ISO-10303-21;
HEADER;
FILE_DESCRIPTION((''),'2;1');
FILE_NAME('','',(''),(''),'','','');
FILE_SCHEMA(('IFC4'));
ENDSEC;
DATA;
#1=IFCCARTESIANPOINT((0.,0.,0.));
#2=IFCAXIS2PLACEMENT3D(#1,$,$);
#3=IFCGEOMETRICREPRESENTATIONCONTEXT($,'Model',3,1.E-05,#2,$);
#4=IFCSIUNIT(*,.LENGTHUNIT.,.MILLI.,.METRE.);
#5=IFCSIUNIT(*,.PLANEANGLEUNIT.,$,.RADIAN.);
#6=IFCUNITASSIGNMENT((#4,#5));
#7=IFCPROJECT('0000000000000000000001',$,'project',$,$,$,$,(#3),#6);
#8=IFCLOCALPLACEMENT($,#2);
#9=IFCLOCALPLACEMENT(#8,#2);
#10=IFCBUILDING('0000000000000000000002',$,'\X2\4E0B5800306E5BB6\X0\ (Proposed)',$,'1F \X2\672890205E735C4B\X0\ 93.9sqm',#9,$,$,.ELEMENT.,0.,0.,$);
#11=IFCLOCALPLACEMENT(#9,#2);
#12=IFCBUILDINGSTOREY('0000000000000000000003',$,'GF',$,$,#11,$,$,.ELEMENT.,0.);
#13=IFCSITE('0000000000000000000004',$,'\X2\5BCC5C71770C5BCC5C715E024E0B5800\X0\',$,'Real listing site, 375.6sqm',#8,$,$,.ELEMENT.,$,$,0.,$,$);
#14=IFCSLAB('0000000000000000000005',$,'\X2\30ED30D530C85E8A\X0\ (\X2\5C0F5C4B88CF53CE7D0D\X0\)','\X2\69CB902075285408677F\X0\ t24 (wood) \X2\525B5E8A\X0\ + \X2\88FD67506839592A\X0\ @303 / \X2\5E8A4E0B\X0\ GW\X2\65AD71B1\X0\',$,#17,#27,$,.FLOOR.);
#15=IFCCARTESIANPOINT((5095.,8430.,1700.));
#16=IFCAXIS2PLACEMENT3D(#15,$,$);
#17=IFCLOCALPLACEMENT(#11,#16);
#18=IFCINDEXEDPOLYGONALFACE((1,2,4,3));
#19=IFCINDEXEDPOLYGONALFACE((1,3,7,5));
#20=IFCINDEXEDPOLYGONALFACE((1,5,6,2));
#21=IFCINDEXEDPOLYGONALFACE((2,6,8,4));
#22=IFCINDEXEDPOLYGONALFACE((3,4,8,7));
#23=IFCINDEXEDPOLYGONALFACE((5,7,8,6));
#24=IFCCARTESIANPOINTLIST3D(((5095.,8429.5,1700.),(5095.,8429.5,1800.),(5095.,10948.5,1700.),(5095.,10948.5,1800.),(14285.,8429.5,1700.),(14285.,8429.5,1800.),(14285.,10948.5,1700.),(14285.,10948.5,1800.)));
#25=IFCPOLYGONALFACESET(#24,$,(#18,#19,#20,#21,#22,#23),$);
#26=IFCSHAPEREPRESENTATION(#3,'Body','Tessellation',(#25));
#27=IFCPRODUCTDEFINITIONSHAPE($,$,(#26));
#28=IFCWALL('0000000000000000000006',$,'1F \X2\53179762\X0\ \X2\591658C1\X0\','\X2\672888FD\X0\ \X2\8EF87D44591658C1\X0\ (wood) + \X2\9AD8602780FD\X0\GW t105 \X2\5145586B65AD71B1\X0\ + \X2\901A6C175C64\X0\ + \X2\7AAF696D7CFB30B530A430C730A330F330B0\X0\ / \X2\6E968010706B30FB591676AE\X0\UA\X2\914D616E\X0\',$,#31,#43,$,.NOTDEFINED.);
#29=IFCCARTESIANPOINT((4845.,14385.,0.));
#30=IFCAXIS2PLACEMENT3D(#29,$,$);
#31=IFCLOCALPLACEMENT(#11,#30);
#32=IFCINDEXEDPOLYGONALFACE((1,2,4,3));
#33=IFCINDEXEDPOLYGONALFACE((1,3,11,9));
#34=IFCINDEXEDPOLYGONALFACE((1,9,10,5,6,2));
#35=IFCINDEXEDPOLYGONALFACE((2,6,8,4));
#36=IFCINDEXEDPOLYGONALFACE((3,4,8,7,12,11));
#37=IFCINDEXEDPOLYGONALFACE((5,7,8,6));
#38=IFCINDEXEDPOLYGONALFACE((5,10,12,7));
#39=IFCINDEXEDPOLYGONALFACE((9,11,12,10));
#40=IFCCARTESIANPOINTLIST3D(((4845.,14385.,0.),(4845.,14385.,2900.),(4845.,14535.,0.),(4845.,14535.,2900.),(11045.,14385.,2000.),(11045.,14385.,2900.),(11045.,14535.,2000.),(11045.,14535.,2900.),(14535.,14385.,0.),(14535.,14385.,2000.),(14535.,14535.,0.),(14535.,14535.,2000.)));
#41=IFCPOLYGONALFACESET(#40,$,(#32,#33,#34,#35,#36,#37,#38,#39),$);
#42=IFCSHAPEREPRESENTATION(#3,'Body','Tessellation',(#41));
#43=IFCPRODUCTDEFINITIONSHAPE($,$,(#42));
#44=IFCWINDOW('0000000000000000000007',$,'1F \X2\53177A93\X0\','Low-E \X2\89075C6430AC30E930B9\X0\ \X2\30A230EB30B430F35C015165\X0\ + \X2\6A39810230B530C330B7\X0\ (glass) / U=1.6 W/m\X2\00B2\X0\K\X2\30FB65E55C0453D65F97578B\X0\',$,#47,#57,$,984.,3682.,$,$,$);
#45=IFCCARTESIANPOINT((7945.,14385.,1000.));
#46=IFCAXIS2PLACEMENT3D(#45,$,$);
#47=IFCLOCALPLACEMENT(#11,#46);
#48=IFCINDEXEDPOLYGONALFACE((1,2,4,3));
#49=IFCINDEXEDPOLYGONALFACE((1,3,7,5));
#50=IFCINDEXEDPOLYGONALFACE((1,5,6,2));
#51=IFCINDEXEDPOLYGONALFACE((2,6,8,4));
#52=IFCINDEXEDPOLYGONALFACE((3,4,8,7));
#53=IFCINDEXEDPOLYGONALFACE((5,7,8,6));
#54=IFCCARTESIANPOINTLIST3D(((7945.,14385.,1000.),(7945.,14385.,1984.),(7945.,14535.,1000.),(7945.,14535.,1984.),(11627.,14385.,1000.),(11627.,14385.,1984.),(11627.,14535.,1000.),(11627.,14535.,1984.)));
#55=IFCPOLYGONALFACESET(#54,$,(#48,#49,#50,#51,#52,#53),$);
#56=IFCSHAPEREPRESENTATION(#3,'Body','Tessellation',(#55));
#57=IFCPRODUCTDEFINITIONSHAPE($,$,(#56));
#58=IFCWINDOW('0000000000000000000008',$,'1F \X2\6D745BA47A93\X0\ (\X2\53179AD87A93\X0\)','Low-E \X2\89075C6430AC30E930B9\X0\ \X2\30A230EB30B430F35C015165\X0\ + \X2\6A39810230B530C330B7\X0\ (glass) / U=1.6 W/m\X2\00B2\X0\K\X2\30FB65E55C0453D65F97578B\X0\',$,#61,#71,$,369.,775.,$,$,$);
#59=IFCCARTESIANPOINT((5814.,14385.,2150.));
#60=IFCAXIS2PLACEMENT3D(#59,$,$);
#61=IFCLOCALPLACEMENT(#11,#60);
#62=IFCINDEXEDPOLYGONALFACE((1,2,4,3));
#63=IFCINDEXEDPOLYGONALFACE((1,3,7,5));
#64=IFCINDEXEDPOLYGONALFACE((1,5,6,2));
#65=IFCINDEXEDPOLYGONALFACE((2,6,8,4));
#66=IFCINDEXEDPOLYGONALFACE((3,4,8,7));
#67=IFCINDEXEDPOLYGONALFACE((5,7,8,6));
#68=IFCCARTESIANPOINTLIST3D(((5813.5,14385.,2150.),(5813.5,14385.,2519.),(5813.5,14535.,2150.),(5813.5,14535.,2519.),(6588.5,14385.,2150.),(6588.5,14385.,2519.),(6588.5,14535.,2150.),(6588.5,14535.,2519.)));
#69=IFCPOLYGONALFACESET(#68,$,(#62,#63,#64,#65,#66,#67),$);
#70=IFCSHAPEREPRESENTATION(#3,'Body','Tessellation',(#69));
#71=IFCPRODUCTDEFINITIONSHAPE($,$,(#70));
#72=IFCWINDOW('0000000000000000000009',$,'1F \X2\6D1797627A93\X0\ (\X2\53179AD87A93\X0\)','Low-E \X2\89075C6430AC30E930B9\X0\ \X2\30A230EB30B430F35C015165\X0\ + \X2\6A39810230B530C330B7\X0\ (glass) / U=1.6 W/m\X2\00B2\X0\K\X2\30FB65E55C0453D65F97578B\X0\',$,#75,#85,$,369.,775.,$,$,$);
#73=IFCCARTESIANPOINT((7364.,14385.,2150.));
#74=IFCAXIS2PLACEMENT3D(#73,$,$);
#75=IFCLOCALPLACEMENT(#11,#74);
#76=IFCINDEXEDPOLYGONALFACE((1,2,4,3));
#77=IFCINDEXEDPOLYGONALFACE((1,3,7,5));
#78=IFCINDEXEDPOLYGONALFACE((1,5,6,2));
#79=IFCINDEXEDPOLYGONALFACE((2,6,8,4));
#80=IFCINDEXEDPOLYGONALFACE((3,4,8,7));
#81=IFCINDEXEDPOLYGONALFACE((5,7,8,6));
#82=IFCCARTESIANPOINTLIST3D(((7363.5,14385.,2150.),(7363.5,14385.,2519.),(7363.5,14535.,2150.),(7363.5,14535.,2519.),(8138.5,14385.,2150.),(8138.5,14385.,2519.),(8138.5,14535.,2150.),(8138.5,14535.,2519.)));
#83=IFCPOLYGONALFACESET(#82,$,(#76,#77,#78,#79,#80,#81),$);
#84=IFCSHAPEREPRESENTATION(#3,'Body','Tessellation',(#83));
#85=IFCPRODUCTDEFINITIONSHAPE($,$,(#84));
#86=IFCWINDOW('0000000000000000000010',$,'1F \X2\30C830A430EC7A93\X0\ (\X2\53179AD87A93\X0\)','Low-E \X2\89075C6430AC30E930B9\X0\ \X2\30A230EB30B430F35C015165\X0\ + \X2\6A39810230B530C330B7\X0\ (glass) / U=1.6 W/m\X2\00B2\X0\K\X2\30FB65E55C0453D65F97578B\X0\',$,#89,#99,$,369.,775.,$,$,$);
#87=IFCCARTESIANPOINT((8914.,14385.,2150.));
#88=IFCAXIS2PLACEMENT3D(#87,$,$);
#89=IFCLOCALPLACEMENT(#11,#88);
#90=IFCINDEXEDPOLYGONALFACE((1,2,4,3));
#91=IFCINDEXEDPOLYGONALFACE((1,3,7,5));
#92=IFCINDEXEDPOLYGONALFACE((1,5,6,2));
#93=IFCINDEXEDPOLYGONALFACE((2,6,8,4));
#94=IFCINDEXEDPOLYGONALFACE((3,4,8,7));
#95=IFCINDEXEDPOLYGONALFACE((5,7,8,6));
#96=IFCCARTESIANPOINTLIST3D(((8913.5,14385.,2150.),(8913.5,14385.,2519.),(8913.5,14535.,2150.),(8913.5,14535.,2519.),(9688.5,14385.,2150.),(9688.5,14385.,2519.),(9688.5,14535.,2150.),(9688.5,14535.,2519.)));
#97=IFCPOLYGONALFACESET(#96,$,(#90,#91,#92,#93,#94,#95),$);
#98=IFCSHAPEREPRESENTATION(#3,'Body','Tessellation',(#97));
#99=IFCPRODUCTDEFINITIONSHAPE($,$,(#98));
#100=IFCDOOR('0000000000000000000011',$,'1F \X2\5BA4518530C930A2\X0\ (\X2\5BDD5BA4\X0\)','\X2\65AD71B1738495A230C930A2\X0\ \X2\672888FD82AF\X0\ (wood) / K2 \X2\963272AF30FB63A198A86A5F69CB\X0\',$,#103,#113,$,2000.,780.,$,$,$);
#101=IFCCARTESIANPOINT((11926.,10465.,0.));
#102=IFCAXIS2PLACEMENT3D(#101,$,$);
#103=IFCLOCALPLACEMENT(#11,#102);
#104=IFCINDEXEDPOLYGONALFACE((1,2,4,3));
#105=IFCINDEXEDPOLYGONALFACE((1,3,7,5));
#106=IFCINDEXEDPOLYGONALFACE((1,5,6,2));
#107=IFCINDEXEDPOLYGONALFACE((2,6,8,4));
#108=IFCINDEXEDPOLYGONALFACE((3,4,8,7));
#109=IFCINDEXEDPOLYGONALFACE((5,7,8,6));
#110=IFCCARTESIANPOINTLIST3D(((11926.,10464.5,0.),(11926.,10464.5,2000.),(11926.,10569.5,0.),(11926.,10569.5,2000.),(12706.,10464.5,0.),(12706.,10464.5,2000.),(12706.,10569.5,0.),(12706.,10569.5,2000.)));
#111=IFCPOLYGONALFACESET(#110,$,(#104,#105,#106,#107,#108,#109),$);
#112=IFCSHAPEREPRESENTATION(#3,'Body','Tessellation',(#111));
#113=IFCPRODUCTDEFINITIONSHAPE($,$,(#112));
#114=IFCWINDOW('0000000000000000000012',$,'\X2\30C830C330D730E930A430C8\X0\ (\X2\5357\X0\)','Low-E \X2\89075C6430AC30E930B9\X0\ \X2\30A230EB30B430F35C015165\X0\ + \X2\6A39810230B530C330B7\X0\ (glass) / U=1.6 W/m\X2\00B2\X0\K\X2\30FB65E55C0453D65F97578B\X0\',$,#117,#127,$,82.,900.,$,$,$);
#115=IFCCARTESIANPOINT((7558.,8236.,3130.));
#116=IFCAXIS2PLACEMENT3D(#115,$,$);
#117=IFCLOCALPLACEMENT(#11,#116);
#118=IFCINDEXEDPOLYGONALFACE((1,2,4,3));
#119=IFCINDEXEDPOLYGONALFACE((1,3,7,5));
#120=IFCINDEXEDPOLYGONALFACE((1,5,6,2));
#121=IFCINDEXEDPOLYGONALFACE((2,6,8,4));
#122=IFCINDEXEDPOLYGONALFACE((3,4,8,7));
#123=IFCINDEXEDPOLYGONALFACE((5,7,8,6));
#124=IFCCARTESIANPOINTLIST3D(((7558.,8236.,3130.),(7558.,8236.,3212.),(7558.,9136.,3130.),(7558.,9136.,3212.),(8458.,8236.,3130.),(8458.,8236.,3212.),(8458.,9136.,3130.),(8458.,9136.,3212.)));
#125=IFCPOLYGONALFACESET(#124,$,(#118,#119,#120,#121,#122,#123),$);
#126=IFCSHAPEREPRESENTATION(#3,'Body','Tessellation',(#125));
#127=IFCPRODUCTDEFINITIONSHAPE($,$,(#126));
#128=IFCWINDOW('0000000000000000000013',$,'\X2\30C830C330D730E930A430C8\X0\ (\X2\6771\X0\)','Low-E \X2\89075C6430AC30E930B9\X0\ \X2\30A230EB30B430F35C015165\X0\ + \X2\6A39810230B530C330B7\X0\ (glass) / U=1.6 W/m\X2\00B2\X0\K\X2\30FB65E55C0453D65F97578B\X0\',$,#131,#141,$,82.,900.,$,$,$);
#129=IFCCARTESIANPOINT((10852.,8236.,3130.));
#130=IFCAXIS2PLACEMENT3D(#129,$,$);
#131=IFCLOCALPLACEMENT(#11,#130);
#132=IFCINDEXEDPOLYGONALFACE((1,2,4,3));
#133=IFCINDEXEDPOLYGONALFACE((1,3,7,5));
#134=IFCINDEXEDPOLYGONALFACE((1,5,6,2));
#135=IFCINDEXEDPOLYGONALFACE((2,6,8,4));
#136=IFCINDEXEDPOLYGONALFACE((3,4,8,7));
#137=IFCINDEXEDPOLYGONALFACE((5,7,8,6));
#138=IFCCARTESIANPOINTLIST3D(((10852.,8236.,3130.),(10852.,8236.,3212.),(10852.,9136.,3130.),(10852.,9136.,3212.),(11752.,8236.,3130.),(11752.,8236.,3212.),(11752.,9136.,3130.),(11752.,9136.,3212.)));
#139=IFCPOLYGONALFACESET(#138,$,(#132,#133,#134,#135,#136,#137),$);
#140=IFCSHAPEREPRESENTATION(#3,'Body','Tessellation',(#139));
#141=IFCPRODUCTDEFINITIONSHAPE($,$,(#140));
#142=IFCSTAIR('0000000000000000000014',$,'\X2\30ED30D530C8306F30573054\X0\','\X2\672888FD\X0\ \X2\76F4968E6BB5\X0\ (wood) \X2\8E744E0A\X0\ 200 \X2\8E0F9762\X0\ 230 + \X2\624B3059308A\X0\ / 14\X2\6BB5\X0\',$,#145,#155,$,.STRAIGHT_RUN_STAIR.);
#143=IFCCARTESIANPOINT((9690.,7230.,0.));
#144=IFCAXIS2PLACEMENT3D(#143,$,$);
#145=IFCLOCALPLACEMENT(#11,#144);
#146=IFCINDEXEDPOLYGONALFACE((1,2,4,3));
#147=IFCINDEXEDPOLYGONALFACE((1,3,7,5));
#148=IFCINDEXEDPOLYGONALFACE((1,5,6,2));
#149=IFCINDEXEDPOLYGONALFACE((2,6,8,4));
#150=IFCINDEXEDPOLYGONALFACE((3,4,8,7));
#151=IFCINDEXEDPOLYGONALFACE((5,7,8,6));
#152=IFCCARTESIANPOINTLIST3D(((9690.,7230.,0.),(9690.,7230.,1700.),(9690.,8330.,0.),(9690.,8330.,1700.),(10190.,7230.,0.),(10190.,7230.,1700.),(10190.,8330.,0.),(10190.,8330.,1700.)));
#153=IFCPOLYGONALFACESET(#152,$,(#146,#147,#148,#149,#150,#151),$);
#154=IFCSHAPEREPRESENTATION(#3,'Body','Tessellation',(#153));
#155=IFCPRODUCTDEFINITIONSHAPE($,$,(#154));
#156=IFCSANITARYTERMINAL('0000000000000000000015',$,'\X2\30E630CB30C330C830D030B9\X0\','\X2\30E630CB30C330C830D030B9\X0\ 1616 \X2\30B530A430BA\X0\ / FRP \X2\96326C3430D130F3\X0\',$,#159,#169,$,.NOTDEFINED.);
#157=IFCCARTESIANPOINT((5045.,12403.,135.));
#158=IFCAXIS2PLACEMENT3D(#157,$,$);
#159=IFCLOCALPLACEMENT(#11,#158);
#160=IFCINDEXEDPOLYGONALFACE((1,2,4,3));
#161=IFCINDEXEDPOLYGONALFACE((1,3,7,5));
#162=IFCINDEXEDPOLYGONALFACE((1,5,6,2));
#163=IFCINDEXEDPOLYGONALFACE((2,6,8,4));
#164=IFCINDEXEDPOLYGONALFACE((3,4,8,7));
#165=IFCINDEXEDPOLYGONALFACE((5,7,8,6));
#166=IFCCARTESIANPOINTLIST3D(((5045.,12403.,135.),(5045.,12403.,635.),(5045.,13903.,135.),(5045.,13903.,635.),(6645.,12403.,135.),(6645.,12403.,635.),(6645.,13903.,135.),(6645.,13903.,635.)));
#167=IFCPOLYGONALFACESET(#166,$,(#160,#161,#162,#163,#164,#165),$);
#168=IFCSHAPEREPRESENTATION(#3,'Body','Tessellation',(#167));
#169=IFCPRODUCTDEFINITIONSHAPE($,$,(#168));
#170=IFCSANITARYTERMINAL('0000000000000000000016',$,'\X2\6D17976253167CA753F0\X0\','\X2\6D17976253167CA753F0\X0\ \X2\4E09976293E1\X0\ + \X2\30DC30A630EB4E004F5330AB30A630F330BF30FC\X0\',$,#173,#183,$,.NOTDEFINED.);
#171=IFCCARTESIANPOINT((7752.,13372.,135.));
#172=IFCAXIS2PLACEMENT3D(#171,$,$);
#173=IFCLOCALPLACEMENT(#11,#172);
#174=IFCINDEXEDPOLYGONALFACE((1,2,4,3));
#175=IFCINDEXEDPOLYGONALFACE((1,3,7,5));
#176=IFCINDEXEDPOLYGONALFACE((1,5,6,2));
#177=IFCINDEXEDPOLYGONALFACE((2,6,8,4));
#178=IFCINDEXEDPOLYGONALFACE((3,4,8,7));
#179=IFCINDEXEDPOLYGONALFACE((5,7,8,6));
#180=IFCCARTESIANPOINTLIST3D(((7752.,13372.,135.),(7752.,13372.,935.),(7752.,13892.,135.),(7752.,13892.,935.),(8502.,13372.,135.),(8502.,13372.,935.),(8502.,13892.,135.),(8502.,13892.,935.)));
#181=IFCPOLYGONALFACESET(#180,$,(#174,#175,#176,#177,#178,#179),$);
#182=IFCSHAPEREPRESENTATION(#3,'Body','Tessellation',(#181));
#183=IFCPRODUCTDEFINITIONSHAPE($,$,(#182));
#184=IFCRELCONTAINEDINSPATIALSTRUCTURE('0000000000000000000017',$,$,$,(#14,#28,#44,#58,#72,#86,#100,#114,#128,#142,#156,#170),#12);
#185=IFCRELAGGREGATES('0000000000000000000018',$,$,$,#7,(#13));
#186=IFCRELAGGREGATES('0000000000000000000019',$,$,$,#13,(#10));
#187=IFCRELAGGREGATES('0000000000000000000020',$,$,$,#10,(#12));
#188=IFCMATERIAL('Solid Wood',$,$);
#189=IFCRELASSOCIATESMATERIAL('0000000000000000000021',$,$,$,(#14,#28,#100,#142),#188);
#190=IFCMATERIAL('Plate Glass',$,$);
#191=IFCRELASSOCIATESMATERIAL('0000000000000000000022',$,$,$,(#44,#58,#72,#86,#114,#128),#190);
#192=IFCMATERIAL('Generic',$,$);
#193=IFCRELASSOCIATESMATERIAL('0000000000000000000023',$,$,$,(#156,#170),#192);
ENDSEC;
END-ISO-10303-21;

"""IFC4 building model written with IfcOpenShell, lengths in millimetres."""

from ifc_helpers import new_model, si_unit, frame, frame_2d, origin, place, context, project, spatial, rectangle, extrude, material, element, fill, save


model = new_model("IFC4")

# Units and contexts
model_context = context("Model", 3, precision=1e-05, world=origin())
ifc_project = project(units=[si_unit("LENGTHUNIT", "METRE", prefix="MILLI"), si_unit("PLANEANGLEUNIT", "RADIAN")], contexts=[model_context])

# Site, building, storey
site_placement = place(None, origin())
site = spatial("IfcSite", under=ifc_project, at=site_placement, Name="富山県富山市下堀", ObjectType="Real listing site, 375.6sqm", CompositionType="ELEMENT", RefElevation=0.0)
building_placement = place(site_placement, origin())
building = spatial("IfcBuilding", under=site, at=building_placement, Name="下堀の家 (Proposed)", ObjectType="1F 木造平屋 93.9sqm", CompositionType="ELEMENT", ElevationOfRefHeight=0.0, ElevationOfTerrain=0.0)
storey_placement = place(building_placement, origin())
storey = spatial("IfcBuildingStorey", under=building, at=storey_placement, Name="GF", CompositionType="ELEMENT", Elevation=0.0)

# Slab
ifc_material_1 = material(Name="Solid Wood")
slab_placement = place(storey_placement, frame((5095.0, 8430.0, 1700.0)))
element("IfcSlab", 1, at=slab_placement, inside=storey, material=ifc_material_1, Name="ロフト床 (小屋裏収納)", Description="構造用合板 t24 (wood) 剛床 + 製材根太 @303 / 床下 GW断熱", PredefinedType="FLOOR", context=model_context, shape_type="SweptSolid", body=[
    extrude(rectangle(XDim=9190.0, YDim=2519.0, at=frame_2d((4595.0, 1259.0))), frame((5095.0, 8430.0, 1700.0)), (0.0, 0.0, 1.0), 100.0),
])

# Wall, openings, windows
wall_1_placement = place(storey_placement, frame((4845.0, 14385.0, 0.0)))
wall_1 = element("IfcWall", 2, at=wall_1_placement, inside=storey, material=ifc_material_1, Name="1F 北面 外壁", Description="木製 軸組外壁 (wood) + 高性能GW t105 充填断熱 + 通気層 + 窯業系サイディング / 準耐火・外皮UA配慮", PredefinedType="NOTDEFINED", context=model_context, shape_type="SweptSolid", body=[
    extrude(rectangle(XDim=9690.0, YDim=150.0, at=frame_2d((4845.0, 75.0))), frame((4845.0, 14385.0, 0.0)), (0.0, 0.0, 1.0), 2900.0),
])
opening_1_placement = place(storey_placement, frame((7945.0, 14385.0, 1000.0)))
opening_1 = element("IfcOpeningElement", 3, at=opening_1_placement, cuts=wall_1, PredefinedType="NOTDEFINED", context=model_context, shape_type="SweptSolid", body=[
    extrude(rectangle(XDim=3682.0, YDim=150.0, at=frame_2d((1841.0, 75.0))), frame((7945.0, 14385.0, 1000.0)), (0.0, 0.0, 1.0), 984.0),
])
opening_2_placement = place(storey_placement, frame((5814.0, 14385.0, 2150.0)))
opening_2 = element("IfcOpeningElement", 4, at=opening_2_placement, cuts=wall_1, PredefinedType="NOTDEFINED", context=model_context, shape_type="SweptSolid", body=[
    extrude(rectangle(XDim=775.0, YDim=150.0, at=frame_2d((387.0, 75.0))), frame((5814.0, 14385.0, 2150.0)), (0.0, 0.0, 1.0), 369.0),
])
opening_3_placement = place(storey_placement, frame((7364.0, 14385.0, 2150.0)))
opening_3 = element("IfcOpeningElement", 5, at=opening_3_placement, cuts=wall_1, PredefinedType="NOTDEFINED", context=model_context, shape_type="SweptSolid", body=[
    extrude(rectangle(XDim=775.0, YDim=150.0, at=frame_2d((387.0, 75.0))), frame((7364.0, 14385.0, 2150.0)), (0.0, 0.0, 1.0), 369.0),
])
opening_4_placement = place(storey_placement, frame((8914.0, 14385.0, 2150.0)))
opening_4 = element("IfcOpeningElement", 6, at=opening_4_placement, cuts=wall_1, PredefinedType="NOTDEFINED", context=model_context, shape_type="SweptSolid", body=[
    extrude(rectangle(XDim=775.0, YDim=150.0, at=frame_2d((387.0, 75.0))), frame((8914.0, 14385.0, 2150.0)), (0.0, 0.0, 1.0), 369.0),
])
ifc_material_2 = material(Name="Plate Glass")
window_1_placement = place(storey_placement, frame((7945.0, 14385.0, 1000.0)))
window_1 = element("IfcWindow", 7, at=window_1_placement, inside=storey, material=ifc_material_2, Name="1F 北窓", Description="Low-E 複層ガラス アルゴン封入 + 樹脂サッシ (glass) / U=1.6 W/m²K・日射取得型", OverallHeight=984.0, OverallWidth=3682.0, context=model_context, shape_type="SweptSolid", body=[
    extrude(rectangle(XDim=3682.0, YDim=150.0, at=frame_2d((1841.0, 75.0))), frame((7945.0, 14385.0, 1000.0)), (0.0, 0.0, 1.0), 984.0),
])
fill(opening_1, window_1)
window_2_placement = place(storey_placement, frame((5814.0, 14385.0, 2150.0)))
window_2 = element("IfcWindow", 8, at=window_2_placement, inside=storey, material=ifc_material_2, Name="1F 浴室窓 (北高窓)", Description="Low-E 複層ガラス アルゴン封入 + 樹脂サッシ (glass) / U=1.6 W/m²K・日射取得型", OverallHeight=369.0, OverallWidth=775.0, context=model_context, shape_type="SweptSolid", body=[
    extrude(rectangle(XDim=775.0, YDim=150.0, at=frame_2d((387.0, 75.0))), frame((5814.0, 14385.0, 2150.0)), (0.0, 0.0, 1.0), 369.0),
])
fill(opening_2, window_2)
window_3_placement = place(storey_placement, frame((7364.0, 14385.0, 2150.0)))
window_3 = element("IfcWindow", 9, at=window_3_placement, inside=storey, material=ifc_material_2, Name="1F 洗面窓 (北高窓)", Description="Low-E 複層ガラス アルゴン封入 + 樹脂サッシ (glass) / U=1.6 W/m²K・日射取得型", OverallHeight=369.0, OverallWidth=775.0, context=model_context, shape_type="SweptSolid", body=[
    extrude(rectangle(XDim=775.0, YDim=150.0, at=frame_2d((387.0, 75.0))), frame((7364.0, 14385.0, 2150.0)), (0.0, 0.0, 1.0), 369.0),
])
fill(opening_3, window_3)
window_4_placement = place(storey_placement, frame((8914.0, 14385.0, 2150.0)))
window_4 = element("IfcWindow", 10, at=window_4_placement, inside=storey, material=ifc_material_2, Name="1F トイレ窓 (北高窓)", Description="Low-E 複層ガラス アルゴン封入 + 樹脂サッシ (glass) / U=1.6 W/m²K・日射取得型", OverallHeight=369.0, OverallWidth=775.0, context=model_context, shape_type="SweptSolid", body=[
    extrude(rectangle(XDim=775.0, YDim=150.0, at=frame_2d((387.0, 75.0))), frame((8914.0, 14385.0, 2150.0)), (0.0, 0.0, 1.0), 369.0),
])
fill(opening_4, window_4)

# Door
door_1_placement = place(storey_placement, frame((11926.0, 10465.0, 0.0)))
element("IfcDoor", 11, at=door_1_placement, inside=storey, material=ifc_material_1, Name="1F 室内ドア (寝室)", Description="断熱玄関ドア 木製芯 (wood) / K2 防犯・採風機構", OverallHeight=2000.0, OverallWidth=780.0, context=model_context, shape_type="SweptSolid", body=[
    extrude(rectangle(XDim=780.0, YDim=105.0, at=frame_2d((390.0, 52.0))), frame((11926.0, 10465.0, 0.0)), (0.0, 0.0, 1.0), 2000.0),
])

# Windows
window_5_placement = place(storey_placement, frame((7558.0, 8236.0, 3130.0)))
element("IfcWindow", 12, at=window_5_placement, inside=storey, material=ifc_material_2, Name="トップライト (南)", Description="Low-E 複層ガラス アルゴン封入 + 樹脂サッシ (glass) / U=1.6 W/m²K・日射取得型", OverallHeight=82.0, OverallWidth=900.0, context=model_context, shape_type="SweptSolid", body=[
    extrude(rectangle(XDim=900.0, YDim=900.0, at=frame_2d((450.0, 450.0))), frame((7558.0, 8236.0, 3130.0)), (0.0, 0.0, 1.0), 82.0),
])
window_6_placement = place(storey_placement, frame((10852.0, 8236.0, 3130.0)))
element("IfcWindow", 13, at=window_6_placement, inside=storey, material=ifc_material_2, Name="トップライト (東)", Description="Low-E 複層ガラス アルゴン封入 + 樹脂サッシ (glass) / U=1.6 W/m²K・日射取得型", OverallHeight=82.0, OverallWidth=900.0, context=model_context, shape_type="SweptSolid", body=[
    extrude(rectangle(XDim=900.0, YDim=900.0, at=frame_2d((450.0, 450.0))), frame((10852.0, 8236.0, 3130.0)), (0.0, 0.0, 1.0), 82.0),
])

# Stair
stair_placement = place(storey_placement, frame((9690.0, 7230.0, 0.0)))
element("IfcStair", 14, at=stair_placement, inside=storey, material=ifc_material_1, Name="ロフトはしご", Description="木製 直階段 (wood) 蹴上 200 踏面 230 + 手すり / 14段", PredefinedType="STRAIGHT_RUN_STAIR", context=model_context, shape_type="SweptSolid", body=[
    extrude(rectangle(XDim=500.0, YDim=1100.0, at=frame_2d((250.0, 550.0))), frame((9690.0, 7230.0, 0.0)), (0.0, 0.0, 1.0), 1700.0),
])

# Sanitary terminals
ifc_material_3 = material(Name="Generic")
sanitary_terminal_1_placement = place(storey_placement, frame((5045.0, 12403.0, 135.0)))
element("IfcSanitaryTerminal", 15, at=sanitary_terminal_1_placement, inside=storey, material=ifc_material_3, Name="ユニットバス", Description="ユニットバス 1616 サイズ / FRP 防水パン", PredefinedType="NOTDEFINED", context=model_context, shape_type="SweptSolid", body=[
    extrude(rectangle(XDim=1600.0, YDim=1500.0, at=frame_2d((800.0, 750.0))), frame((5045.0, 12403.0, 135.0)), (0.0, 0.0, 1.0), 500.0),
])
sanitary_terminal_2_placement = place(storey_placement, frame((7752.0, 13372.0, 135.0)))
element("IfcSanitaryTerminal", 16, at=sanitary_terminal_2_placement, inside=storey, material=ifc_material_3, Name="洗面化粧台", Description="洗面化粧台 三面鏡 + ボウル一体カウンター", PredefinedType="NOTDEFINED", context=model_context, shape_type="SweptSolid", body=[
    extrude(rectangle(XDim=750.0, YDim=520.0, at=frame_2d((375.0, 260.0))), frame((7752.0, 13372.0, 135.0)), (0.0, 0.0, 1.0), 800.0),
])

save(model, "model.ifc")
